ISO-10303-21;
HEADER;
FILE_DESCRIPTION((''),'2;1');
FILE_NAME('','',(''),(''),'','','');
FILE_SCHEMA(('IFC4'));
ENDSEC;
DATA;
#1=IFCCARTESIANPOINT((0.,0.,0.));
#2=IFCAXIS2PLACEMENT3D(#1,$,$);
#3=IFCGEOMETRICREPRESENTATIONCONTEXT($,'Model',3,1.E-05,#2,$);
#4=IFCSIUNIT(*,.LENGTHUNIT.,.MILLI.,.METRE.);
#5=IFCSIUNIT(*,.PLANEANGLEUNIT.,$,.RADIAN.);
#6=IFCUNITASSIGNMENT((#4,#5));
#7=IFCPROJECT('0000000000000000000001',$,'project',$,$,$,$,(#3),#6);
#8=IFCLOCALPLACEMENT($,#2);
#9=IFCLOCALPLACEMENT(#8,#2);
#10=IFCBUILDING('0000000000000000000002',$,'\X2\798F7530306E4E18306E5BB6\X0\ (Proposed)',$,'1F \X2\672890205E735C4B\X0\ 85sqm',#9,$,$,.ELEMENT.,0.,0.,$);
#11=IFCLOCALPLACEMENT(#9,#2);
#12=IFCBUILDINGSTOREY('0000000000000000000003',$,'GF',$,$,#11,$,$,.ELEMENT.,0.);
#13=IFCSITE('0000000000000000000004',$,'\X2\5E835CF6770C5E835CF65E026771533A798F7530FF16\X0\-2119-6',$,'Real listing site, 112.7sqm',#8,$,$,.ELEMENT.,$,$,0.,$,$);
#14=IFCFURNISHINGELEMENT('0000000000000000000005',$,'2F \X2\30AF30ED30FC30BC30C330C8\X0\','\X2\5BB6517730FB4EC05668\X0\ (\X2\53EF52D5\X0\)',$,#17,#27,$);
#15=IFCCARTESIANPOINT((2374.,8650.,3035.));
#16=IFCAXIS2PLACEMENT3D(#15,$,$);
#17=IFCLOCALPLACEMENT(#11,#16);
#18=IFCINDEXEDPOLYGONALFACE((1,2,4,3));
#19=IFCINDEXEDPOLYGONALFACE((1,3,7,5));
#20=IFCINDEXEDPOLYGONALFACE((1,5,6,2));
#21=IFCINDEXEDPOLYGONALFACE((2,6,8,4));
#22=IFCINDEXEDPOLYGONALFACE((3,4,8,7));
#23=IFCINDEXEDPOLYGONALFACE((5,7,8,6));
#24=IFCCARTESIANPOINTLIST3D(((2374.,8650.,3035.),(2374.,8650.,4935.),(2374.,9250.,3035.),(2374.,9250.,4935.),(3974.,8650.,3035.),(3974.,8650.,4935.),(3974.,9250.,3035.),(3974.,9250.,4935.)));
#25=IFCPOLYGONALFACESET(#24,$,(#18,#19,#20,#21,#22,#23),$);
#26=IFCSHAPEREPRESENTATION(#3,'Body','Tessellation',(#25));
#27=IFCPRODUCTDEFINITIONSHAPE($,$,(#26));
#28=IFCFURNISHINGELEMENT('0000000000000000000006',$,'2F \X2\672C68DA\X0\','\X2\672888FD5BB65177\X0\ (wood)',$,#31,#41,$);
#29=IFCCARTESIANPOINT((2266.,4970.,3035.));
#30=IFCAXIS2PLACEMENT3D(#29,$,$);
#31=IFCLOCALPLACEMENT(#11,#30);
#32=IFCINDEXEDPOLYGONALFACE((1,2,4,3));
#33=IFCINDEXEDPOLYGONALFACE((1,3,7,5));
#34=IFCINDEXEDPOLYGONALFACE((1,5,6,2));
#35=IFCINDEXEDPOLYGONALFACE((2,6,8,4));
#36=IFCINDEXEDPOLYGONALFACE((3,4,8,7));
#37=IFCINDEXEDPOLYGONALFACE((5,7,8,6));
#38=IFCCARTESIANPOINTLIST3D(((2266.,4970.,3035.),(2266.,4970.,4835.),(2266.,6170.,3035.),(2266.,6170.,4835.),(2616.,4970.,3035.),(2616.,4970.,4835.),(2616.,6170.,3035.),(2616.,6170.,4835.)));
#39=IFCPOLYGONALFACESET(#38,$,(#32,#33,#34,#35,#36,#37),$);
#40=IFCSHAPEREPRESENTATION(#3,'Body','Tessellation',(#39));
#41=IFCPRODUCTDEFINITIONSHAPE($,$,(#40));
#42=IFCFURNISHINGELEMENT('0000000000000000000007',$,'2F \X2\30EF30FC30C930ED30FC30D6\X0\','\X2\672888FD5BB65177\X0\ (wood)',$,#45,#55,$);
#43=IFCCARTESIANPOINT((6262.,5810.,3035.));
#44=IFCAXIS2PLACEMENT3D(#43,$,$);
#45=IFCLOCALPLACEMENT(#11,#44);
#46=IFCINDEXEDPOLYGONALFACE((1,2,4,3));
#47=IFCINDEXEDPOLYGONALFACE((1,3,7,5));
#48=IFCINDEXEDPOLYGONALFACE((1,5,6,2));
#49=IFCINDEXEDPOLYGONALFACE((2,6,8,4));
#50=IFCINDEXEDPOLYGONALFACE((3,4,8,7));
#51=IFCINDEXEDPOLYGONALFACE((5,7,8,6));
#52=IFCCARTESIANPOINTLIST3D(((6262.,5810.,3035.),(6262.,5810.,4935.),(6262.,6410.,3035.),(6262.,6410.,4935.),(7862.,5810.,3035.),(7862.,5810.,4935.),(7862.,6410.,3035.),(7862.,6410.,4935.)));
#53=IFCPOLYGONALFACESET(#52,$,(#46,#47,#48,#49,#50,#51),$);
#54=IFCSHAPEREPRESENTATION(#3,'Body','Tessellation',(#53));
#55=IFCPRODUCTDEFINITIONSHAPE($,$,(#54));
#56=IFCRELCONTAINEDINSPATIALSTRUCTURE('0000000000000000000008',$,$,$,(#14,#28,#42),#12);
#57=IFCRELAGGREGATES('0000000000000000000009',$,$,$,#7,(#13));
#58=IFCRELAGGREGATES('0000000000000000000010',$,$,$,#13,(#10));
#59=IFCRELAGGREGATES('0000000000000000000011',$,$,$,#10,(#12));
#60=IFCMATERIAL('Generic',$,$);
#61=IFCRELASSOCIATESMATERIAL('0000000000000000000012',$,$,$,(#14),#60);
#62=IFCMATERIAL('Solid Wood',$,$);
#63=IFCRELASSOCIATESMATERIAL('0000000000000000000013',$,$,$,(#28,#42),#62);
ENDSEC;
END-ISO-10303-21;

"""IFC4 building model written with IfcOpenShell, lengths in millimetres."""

from ifc_helpers import new_model, si_unit, frame, frame_2d, origin, place, context, project, spatial, rectangle, extrude, material, element, save


model = new_model("IFC4")

# Units and contexts
model_context = context("Model", 3, precision=1e-05, world=origin())
ifc_project = project(units=[si_unit("LENGTHUNIT", "METRE", prefix="MILLI"), si_unit("PLANEANGLEUNIT", "RADIAN")], contexts=[model_context])

# Site, building, storey
site_placement = place(None, origin())
site = spatial("IfcSite", under=ifc_project, at=site_placement, Name="広島県広島市東区福田６-2119-6", ObjectType="Real listing site, 112.7sqm", CompositionType="ELEMENT", RefElevation=0.0)
building_placement = place(site_placement, origin())
building = spatial("IfcBuilding", under=site, at=building_placement, Name="福田の丘の家 (Proposed)", ObjectType="1F 木造平屋 85sqm", CompositionType="ELEMENT", ElevationOfRefHeight=0.0, ElevationOfTerrain=0.0)
storey_placement = place(building_placement, origin())
storey = spatial("IfcBuildingStorey", under=building, at=storey_placement, Name="GF", CompositionType="ELEMENT", Elevation=0.0)

# Shared definitions
ifc_material_1 = material(Name="Solid Wood")

# Shared definitions
ifc_material_2 = material(Name="Generic")

# Furnishing elements
furnishing_1_placement = place(storey_placement, frame((2374.0, 8650.0, 3035.0)))
element("IfcFurnishingElement", 1, at=furnishing_1_placement, inside=storey, material=ifc_material_2, Name="2F クローゼット", Description="家具・什器 (可動)", context=model_context, shape_type="SweptSolid", body=[
    extrude(rectangle(XDim=1600.0, YDim=600.0, at=frame_2d((800.0, 300.0))), frame((2374.0, 8650.0, 3035.0)), (0.0, 0.0, 1.0), 1900.0),
])
furnishing_2_placement = place(storey_placement, frame((2266.0, 4970.0, 3035.0)))
element("IfcFurnishingElement", 2, at=furnishing_2_placement, inside=storey, material=ifc_material_1, Name="2F 本棚", Description="木製家具 (wood)", context=model_context, shape_type="SweptSolid", body=[
    extrude(rectangle(XDim=350.0, YDim=1200.0, at=frame_2d((175.0, 600.0))), frame((2266.0, 4970.0, 3035.0)), (0.0, 0.0, 1.0), 1800.0),
])
furnishing_3_placement = place(storey_placement, frame((6262.0, 5810.0, 3035.0)))
element("IfcFurnishingElement", 3, at=furnishing_3_placement, inside=storey, material=ifc_material_1, Name="2F ワードローブ", Description="木製家具 (wood)", context=model_context, shape_type="SweptSolid", body=[
    extrude(rectangle(XDim=1600.0, YDim=600.0, at=frame_2d((800.0, 300.0))), frame((6262.0, 5810.0, 3035.0)), (0.0, 0.0, 1.0), 1900.0),
])

save(model, "model.ifc")
